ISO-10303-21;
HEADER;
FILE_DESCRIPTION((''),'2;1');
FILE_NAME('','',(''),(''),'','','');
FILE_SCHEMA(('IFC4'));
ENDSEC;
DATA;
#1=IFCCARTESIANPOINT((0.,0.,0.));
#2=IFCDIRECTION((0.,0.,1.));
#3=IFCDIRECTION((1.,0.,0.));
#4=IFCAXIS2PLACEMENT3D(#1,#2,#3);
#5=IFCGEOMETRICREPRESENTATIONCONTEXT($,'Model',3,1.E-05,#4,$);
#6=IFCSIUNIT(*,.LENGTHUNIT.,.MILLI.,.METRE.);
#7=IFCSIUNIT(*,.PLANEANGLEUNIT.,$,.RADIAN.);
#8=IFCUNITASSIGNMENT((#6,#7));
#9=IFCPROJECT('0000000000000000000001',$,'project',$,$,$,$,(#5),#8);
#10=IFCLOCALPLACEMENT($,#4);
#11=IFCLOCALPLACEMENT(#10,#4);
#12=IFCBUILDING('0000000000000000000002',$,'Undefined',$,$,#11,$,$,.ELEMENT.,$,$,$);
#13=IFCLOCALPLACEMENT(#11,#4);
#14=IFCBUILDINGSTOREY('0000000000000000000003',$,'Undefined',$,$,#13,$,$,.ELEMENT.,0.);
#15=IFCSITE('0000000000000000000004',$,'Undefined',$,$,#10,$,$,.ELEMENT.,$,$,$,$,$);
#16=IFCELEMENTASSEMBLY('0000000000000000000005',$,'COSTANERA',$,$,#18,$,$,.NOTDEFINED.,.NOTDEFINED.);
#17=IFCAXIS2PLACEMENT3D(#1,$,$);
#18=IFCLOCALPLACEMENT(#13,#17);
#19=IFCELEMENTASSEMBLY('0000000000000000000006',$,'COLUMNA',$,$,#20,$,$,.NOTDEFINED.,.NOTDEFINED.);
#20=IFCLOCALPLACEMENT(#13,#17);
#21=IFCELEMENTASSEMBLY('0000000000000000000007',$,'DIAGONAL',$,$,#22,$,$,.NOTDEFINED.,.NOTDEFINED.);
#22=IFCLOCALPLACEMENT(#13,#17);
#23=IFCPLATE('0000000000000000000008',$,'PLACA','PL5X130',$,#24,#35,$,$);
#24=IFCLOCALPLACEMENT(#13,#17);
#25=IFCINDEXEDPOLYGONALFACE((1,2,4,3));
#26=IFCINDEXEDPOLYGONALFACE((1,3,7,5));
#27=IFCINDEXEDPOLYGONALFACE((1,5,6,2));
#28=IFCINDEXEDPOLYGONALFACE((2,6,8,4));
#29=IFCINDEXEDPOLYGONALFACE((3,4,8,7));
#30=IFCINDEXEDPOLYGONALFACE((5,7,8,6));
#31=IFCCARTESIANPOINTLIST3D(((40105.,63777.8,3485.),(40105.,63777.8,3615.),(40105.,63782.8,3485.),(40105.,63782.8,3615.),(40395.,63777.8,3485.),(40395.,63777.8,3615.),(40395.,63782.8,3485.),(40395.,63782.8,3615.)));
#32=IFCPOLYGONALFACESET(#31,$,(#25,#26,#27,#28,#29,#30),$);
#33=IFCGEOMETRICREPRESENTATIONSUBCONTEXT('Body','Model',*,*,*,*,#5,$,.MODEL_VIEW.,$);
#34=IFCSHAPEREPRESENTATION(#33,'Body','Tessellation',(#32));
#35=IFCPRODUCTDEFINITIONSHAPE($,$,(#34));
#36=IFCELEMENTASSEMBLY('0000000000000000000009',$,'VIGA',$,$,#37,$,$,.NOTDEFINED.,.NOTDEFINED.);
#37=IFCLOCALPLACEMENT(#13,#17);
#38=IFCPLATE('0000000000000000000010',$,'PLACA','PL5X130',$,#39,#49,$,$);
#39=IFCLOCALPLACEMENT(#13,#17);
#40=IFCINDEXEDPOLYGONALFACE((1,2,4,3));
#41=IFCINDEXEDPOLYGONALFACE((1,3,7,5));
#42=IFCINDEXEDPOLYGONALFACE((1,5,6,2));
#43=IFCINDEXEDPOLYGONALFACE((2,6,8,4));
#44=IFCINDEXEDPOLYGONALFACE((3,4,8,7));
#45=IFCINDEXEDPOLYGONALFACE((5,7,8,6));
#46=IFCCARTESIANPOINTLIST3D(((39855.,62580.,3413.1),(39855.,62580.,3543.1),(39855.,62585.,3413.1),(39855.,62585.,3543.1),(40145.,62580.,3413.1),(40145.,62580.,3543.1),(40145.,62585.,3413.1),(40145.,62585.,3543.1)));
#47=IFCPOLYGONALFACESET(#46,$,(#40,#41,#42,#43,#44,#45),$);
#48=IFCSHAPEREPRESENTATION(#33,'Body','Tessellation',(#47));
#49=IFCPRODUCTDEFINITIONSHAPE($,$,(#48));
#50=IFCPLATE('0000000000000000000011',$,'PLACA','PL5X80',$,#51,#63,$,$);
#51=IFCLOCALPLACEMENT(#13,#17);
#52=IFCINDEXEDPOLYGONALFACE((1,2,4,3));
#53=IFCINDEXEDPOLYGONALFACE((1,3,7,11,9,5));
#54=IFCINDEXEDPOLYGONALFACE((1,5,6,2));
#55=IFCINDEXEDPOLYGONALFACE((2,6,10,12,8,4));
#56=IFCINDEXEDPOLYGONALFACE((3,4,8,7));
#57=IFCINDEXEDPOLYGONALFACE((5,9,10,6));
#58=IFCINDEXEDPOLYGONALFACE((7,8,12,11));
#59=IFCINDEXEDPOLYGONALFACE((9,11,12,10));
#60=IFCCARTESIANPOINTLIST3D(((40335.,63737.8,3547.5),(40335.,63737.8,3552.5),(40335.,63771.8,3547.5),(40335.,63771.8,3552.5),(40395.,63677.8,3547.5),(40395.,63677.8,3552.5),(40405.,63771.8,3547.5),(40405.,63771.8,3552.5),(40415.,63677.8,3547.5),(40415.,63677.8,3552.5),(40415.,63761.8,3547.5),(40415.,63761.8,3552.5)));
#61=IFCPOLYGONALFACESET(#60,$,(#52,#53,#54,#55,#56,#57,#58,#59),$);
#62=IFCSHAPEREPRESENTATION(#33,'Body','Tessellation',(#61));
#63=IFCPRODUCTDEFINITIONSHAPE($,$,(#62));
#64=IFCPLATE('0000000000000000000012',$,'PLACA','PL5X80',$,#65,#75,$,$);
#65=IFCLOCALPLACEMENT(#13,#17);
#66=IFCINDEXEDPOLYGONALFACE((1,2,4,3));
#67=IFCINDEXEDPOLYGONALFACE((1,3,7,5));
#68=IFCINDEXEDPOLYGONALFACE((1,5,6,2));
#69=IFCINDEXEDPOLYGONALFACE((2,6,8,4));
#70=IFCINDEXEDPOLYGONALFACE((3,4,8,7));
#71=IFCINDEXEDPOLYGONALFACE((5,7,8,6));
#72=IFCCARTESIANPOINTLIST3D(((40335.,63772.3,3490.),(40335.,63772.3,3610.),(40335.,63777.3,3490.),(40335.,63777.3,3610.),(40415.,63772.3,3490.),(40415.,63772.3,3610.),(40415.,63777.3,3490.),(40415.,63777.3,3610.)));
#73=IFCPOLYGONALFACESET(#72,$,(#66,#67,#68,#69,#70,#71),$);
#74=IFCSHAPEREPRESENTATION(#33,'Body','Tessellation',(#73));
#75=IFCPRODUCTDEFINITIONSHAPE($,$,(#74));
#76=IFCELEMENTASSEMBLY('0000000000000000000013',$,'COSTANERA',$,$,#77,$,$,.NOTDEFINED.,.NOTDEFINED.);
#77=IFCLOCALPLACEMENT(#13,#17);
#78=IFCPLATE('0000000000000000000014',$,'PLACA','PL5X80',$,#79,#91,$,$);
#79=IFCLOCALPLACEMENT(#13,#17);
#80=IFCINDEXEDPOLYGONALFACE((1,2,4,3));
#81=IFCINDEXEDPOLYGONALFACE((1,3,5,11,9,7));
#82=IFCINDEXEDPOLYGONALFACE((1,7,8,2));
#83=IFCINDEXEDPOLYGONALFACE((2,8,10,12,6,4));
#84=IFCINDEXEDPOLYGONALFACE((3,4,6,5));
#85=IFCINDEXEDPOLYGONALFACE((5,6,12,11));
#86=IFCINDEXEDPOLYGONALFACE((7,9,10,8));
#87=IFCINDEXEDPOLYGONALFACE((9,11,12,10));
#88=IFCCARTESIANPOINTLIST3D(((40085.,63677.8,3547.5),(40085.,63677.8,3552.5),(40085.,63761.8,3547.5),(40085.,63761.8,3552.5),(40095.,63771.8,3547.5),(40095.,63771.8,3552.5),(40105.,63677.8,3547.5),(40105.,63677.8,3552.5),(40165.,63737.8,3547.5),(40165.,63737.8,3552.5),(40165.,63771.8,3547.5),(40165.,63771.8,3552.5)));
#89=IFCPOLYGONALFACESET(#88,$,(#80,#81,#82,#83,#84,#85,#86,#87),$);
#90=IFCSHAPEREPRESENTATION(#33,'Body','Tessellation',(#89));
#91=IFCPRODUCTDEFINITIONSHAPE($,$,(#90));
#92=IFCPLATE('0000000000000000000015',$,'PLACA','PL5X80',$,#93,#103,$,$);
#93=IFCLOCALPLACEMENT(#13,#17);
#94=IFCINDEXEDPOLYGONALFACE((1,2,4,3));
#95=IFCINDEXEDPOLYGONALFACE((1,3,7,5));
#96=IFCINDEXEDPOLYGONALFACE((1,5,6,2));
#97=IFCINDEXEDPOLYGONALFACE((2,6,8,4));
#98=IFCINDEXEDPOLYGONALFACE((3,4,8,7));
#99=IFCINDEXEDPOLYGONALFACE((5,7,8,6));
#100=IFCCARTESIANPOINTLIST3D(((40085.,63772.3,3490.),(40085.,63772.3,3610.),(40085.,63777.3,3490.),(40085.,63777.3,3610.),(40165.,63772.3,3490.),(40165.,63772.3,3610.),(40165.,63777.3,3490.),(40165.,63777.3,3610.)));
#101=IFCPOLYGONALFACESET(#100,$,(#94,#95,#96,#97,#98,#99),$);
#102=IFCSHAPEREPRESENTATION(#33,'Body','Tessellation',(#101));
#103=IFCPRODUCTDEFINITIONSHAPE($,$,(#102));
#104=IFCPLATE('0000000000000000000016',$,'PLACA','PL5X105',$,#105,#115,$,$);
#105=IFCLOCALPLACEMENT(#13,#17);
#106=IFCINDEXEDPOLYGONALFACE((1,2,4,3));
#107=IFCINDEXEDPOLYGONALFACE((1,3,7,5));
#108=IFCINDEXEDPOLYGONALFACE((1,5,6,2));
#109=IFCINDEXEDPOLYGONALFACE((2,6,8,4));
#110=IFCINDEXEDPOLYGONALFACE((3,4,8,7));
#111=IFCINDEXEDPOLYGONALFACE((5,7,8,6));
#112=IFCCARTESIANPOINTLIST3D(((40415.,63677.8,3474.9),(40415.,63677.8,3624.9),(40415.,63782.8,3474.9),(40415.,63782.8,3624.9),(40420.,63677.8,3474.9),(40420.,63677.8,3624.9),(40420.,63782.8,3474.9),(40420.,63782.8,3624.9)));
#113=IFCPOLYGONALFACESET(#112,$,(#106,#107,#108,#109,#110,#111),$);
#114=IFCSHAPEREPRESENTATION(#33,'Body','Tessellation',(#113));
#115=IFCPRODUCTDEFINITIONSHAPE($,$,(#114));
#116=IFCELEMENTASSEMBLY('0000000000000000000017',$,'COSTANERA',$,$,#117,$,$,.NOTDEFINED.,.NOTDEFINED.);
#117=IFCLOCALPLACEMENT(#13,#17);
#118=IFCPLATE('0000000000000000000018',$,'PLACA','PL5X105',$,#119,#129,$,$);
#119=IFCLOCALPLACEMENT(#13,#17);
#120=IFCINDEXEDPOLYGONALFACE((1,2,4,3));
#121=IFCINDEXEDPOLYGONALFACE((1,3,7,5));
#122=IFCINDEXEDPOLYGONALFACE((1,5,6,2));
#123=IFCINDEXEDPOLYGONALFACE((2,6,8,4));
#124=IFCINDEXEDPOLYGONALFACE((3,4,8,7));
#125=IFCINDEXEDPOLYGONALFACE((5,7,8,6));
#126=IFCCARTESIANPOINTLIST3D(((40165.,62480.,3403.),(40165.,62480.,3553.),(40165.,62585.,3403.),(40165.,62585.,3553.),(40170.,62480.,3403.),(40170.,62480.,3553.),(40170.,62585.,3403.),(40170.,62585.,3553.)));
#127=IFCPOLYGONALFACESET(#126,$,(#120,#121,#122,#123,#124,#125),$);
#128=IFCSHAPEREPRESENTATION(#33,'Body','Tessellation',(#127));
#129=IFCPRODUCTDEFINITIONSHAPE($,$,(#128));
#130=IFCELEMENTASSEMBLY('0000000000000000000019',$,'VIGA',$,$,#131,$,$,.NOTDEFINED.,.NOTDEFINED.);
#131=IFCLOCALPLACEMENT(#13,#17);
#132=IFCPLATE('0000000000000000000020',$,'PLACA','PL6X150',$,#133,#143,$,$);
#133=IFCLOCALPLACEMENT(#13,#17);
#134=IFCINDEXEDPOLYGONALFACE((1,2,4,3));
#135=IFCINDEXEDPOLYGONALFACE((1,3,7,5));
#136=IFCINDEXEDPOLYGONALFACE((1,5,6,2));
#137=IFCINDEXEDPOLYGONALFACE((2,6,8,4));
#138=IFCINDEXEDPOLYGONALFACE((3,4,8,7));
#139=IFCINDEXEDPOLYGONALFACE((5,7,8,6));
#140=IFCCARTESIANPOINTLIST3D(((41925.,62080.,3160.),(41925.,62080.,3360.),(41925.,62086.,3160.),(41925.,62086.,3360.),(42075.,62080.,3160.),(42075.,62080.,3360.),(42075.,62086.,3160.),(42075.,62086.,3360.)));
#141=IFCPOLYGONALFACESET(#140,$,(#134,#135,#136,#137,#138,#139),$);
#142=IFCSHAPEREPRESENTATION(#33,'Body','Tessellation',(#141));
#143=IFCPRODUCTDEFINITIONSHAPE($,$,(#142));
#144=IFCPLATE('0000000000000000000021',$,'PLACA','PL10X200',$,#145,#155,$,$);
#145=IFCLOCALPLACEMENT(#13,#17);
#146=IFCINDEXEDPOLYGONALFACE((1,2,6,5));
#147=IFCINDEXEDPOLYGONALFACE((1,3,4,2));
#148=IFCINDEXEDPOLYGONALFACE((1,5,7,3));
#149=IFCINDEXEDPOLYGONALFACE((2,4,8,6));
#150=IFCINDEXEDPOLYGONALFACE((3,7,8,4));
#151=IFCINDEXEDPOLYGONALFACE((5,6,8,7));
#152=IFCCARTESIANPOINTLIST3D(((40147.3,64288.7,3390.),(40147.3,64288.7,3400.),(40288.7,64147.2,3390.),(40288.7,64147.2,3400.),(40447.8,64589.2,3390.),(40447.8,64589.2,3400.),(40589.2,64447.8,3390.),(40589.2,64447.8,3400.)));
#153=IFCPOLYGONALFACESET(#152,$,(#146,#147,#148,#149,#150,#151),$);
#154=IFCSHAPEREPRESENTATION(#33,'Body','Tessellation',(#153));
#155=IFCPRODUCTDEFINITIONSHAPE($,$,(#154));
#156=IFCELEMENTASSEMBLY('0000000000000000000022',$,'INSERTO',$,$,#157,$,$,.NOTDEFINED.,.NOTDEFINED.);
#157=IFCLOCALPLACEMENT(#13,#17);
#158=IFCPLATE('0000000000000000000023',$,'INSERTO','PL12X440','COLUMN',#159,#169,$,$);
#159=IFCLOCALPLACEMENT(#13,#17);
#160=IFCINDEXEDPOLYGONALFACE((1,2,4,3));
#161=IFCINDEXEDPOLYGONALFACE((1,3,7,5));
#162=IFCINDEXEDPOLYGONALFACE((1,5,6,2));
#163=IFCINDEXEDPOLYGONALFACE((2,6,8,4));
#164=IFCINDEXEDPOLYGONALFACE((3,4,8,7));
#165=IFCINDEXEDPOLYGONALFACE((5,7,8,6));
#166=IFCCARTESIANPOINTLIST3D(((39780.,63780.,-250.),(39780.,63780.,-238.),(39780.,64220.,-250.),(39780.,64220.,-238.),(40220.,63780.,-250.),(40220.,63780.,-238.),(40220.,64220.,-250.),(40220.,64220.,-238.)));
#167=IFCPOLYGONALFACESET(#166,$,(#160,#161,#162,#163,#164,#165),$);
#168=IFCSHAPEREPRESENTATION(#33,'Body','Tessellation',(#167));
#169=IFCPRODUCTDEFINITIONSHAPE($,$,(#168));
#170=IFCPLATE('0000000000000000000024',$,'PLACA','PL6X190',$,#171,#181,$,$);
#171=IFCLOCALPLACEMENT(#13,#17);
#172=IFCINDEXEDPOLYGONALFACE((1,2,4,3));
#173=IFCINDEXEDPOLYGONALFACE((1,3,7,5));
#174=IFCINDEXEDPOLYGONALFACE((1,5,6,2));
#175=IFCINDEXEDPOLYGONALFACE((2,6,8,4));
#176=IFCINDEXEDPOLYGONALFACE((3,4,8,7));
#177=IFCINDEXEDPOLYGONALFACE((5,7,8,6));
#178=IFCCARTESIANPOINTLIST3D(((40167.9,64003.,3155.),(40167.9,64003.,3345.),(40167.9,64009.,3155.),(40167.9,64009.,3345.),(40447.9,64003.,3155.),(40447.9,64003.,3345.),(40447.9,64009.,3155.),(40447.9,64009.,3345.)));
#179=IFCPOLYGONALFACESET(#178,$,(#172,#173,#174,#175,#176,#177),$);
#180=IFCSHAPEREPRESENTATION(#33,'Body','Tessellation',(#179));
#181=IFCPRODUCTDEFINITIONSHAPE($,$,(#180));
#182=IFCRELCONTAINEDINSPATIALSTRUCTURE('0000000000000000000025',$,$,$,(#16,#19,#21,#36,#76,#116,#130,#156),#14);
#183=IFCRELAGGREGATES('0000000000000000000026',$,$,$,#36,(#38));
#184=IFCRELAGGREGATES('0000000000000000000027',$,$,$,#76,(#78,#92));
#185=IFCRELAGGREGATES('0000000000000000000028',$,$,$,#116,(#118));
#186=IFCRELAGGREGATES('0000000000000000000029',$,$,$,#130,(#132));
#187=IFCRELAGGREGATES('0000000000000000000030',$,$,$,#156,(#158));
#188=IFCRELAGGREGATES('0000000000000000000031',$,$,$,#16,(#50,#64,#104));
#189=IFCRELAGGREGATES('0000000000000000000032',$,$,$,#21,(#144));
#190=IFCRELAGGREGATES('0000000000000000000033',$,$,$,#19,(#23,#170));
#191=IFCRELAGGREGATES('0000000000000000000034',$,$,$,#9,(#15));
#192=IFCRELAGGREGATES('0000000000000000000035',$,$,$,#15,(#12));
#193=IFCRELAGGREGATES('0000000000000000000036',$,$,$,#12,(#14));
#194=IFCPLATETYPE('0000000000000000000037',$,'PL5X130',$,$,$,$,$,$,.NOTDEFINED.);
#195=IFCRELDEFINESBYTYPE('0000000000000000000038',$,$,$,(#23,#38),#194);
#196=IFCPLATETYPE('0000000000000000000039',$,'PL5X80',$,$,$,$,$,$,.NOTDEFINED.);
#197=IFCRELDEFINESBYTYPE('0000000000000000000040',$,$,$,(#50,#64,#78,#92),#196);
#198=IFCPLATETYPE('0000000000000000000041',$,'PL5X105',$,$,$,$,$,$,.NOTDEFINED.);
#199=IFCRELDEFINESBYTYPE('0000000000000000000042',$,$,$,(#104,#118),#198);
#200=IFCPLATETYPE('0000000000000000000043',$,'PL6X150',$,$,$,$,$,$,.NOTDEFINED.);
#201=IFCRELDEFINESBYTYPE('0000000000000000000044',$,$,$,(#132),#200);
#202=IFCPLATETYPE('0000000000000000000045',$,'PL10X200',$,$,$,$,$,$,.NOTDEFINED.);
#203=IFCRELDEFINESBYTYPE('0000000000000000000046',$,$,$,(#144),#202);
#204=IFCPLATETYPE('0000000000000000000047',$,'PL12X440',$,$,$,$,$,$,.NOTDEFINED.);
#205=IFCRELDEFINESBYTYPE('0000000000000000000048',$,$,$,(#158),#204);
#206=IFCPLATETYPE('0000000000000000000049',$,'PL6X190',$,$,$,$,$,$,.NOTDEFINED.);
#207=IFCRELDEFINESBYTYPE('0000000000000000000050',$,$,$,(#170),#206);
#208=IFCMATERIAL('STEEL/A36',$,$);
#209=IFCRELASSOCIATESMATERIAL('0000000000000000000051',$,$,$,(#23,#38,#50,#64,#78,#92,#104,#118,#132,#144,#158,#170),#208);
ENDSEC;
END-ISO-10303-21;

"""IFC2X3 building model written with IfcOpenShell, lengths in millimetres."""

from ifc_helpers import new_model, si_unit, frame, origin_with_axes, place, context, subcontext, project, spatial, polyline, outline, extrude, material, type_object, element, aggregate, save


model = new_model("IFC2X3")

# Units and contexts
model_context = context("Model", 3, precision=1e-05, world=origin_with_axes())
body_context = subcontext(model_context, "Body", "Model", "MODEL_VIEW")
ifc_project = project(units=[si_unit("LENGTHUNIT", "METRE", prefix="MILLI"), si_unit("PLANEANGLEUNIT", "RADIAN")], contexts=[model_context])

# Site, building, storey
site_placement = place(None, origin_with_axes())
site = spatial("IfcSite", under=ifc_project, at=site_placement, Name="Undefined", CompositionType="ELEMENT")
building_placement = place(site_placement, origin_with_axes())
building = spatial("IfcBuilding", under=site, at=building_placement, Name="Undefined", CompositionType="ELEMENT")
storey_placement = place(building_placement, origin_with_axes())
storey = spatial("IfcBuildingStorey", under=building, at=storey_placement, Name="Undefined", CompositionType="ELEMENT", Elevation=0.0)

# Shared definitions
ifc_material_1 = material(Name="STEEL/A36")

# Element assemblies
assembly_1_placement = place(storey_placement, origin_with_axes())
assembly_1 = element("IfcElementAssembly", 1, at=assembly_1_placement, inside=storey, Name="COSTANERA", AssemblyPlace="NOTDEFINED", PredefinedType="NOTDEFINED")
assembly_2_placement = place(storey_placement, origin_with_axes())
assembly_2 = element("IfcElementAssembly", 2, at=assembly_2_placement, inside=storey, Name="COLUMNA", AssemblyPlace="NOTDEFINED", PredefinedType="NOTDEFINED")

# Element assembly
assembly_3_placement = place(storey_placement, origin_with_axes())
assembly_3 = element("IfcElementAssembly", 3, at=assembly_3_placement, inside=storey, Name="DIAGONAL", AssemblyPlace="NOTDEFINED", PredefinedType="NOTDEFINED")

# Plate
plate_type_1 = type_object("IfcPlateType", Name="PL5X130", PredefinedType="NOTDEFINED")
plate_1_placement = place(assembly_2_placement, frame((40395.0, 63780.3, 3615.0), z_axis=(0.0, -1.0, 0.0), x_axis=(-1.0, 0.0, 0.0)))
plate_1 = element("IfcPlate", 4, at=plate_1_placement, type_object=plate_type_1, material=ifc_material_1, Name="PLACA", Description="PL5X130", context=body_context, shape_type="SweptSolid", body=[
    extrude(outline(polyline([(0.0, 0.0), (290.0, 0.0), (290.0, 130.0), (0.0, 130.0), (0.0, 0.0)])), frame((0.0, 0.0, -2.5), z_axis=(0.0, 0.0, 1.0), x_axis=(1.0, 0.0, 0.0)), (0.0, 0.0, 1.0), 5.0),
])

# Element assembly, plate
assembly_4_placement = place(storey_placement, origin_with_axes())
assembly_4 = element("IfcElementAssembly", 5, at=assembly_4_placement, inside=storey, Name="VIGA", AssemblyPlace="NOTDEFINED", PredefinedType="NOTDEFINED")
plate_2_placement = place(assembly_4_placement, frame((40145.0, 62582.5, 3543.1), z_axis=(0.0, -1.0, 0.0), x_axis=(-1.0, 0.0, 0.0)))
plate_2 = element("IfcPlate", 6, at=plate_2_placement, type_object=plate_type_1, material=ifc_material_1, Name="PLACA", Description="PL5X130", context=body_context, shape_type="SweptSolid", body=[
    extrude(outline(polyline([(0.0, 0.0), (290.0, 0.0), (290.0, 130.0), (0.0, 130.0), (0.0, 0.0)])), frame((0.0, 0.0, -2.5), z_axis=(0.0, 0.0, 1.0), x_axis=(1.0, 0.0, 0.0)), (0.0, 0.0, 1.0), 5.0),
])
aggregate(assembly_4, [plate_2])

# Plates
plate_type_2 = type_object("IfcPlateType", Name="PL5X80", PredefinedType="NOTDEFINED")
plate_3_placement = place(assembly_1_placement, frame((40335.0, 63771.8, 3550.0), z_axis=(0.0, 0.0, -1.0), x_axis=(1.0, 0.0, 0.0)))
plate_3 = element("IfcPlate", 7, at=plate_3_placement, type_object=plate_type_2, material=ifc_material_1, Name="PLACA", Description="PL5X80", context=body_context, shape_type="SweptSolid", body=[
    extrude(outline(polyline([(0.0, 0.0), (70.0, 0.0), (80.0, 10.0), (80.0, 94.0), (60.0, 94.0), (0.0, 34.0), (0.0, 0.0)])), frame((0.0, 0.0, -2.5), z_axis=(0.0, 0.0, 1.0), x_axis=(1.0, 0.0, 0.0)), (0.0, 0.0, 1.0), 5.0),
])
plate_4_placement = place(assembly_1_placement, frame((40335.0, 63774.8, 3610.0), z_axis=(0.0, 1.0, 0.0), x_axis=(1.0, 0.0, 0.0)))
plate_4 = element("IfcPlate", 8, at=plate_4_placement, type_object=plate_type_2, material=ifc_material_1, Name="PLACA", Description="PL5X80", context=body_context, shape_type="SweptSolid", body=[
    extrude(outline(polyline([(0.0, 0.0), (80.0, 0.0), (80.0, 120.0), (0.0, 120.0), (0.0, 0.0)])), frame((0.0, 0.0, -2.5), z_axis=(0.0, 0.0, 1.0), x_axis=(1.0, 0.0, 0.0)), (0.0, 0.0, 1.0), 5.0),
])

# Element assembly, plates
assembly_5_placement = place(storey_placement, origin_with_axes())
assembly_5 = element("IfcElementAssembly", 9, at=assembly_5_placement, inside=storey, Name="COSTANERA", AssemblyPlace="NOTDEFINED", PredefinedType="NOTDEFINED")
plate_5_placement = place(assembly_5_placement, frame((40165.0, 63771.8, 3550.0), z_axis=(0.0, 0.0, 1.0), x_axis=(-1.0, 0.0, 0.0)))
plate_5 = element("IfcPlate", 10, at=plate_5_placement, type_object=plate_type_2, material=ifc_material_1, Name="PLACA", Description="PL5X80", context=body_context, shape_type="SweptSolid", body=[
    extrude(outline(polyline([(0.0, 0.0), (70.0, 0.0), (80.0, 10.0), (80.0, 94.0), (60.0, 94.0), (0.0, 34.0), (0.0, 0.0)])), frame((0.0, 0.0, -2.5), z_axis=(0.0, 0.0, 1.0), x_axis=(1.0, 0.0, 0.0)), (0.0, 0.0, 1.0), 5.0),
])
plate_6_placement = place(assembly_5_placement, frame((40165.0, 63774.8, 3610.0), z_axis=(0.0, -1.0, 0.0), x_axis=(-1.0, 0.0, 0.0)))
plate_6 = element("IfcPlate", 11, at=plate_6_placement, type_object=plate_type_2, material=ifc_material_1, Name="PLACA", Description="PL5X80", context=body_context, shape_type="SweptSolid", body=[
    extrude(outline(polyline([(0.0, 0.0), (80.0, 0.0), (80.0, 120.0), (0.0, 120.0), (0.0, 0.0)])), frame((0.0, 0.0, -2.5), z_axis=(0.0, 0.0, 1.0), x_axis=(1.0, 0.0, 0.0)), (0.0, 0.0, 1.0), 5.0),
])
aggregate(assembly_5, [plate_5, plate_6])

# Plate
plate_type_3 = type_object("IfcPlateType", Name="PL5X105", PredefinedType="NOTDEFINED")
plate_7_placement = place(assembly_1_placement, frame((40417.5, 63677.8, 3474.9), z_axis=(1.0, 0.0, 0.0), x_axis=(0.0, 1.0, 0.0)))
plate_7 = element("IfcPlate", 12, at=plate_7_placement, type_object=plate_type_3, material=ifc_material_1, Name="PLACA", Description="PL5X105", context=body_context, shape_type="SweptSolid", body=[
    extrude(outline(polyline([(0.0, 0.0), (105.0, 0.0), (105.0, 150.0), (0.0, 150.0), (0.0, 0.0)])), frame((0.0, 0.0, -2.5), z_axis=(0.0, 0.0, 1.0), x_axis=(1.0, 0.0, 0.0)), (0.0, 0.0, 1.0), 5.0),
])

# Element assemblies, plates
assembly_6_placement = place(storey_placement, origin_with_axes())
assembly_6 = element("IfcElementAssembly", 13, at=assembly_6_placement, inside=storey, Name="COSTANERA", AssemblyPlace="NOTDEFINED", PredefinedType="NOTDEFINED")
plate_8_placement = place(assembly_6_placement, frame((40167.5, 62480.0, 3403.0), z_axis=(1.0, 0.0, 0.0), x_axis=(0.0, 1.0, 0.0)))
plate_8 = element("IfcPlate", 14, at=plate_8_placement, type_object=plate_type_3, material=ifc_material_1, Name="PLACA", Description="PL5X105", context=body_context, shape_type="SweptSolid", body=[
    extrude(outline(polyline([(0.0, 0.0), (105.0, 0.0), (105.0, 150.0), (0.0, 150.0), (0.0, 0.0)])), frame((0.0, 0.0, -2.5), z_axis=(0.0, 0.0, 1.0), x_axis=(1.0, 0.0, 0.0)), (0.0, 0.0, 1.0), 5.0),
])
aggregate(assembly_6, [plate_8])
assembly_7_placement = place(storey_placement, origin_with_axes())
assembly_7 = element("IfcElementAssembly", 15, at=assembly_7_placement, inside=storey, Name="VIGA", AssemblyPlace="NOTDEFINED", PredefinedType="NOTDEFINED")
plate_type_4 = type_object("IfcPlateType", Name="PL6X150", PredefinedType="NOTDEFINED")
plate_9_placement = place(assembly_7_placement, frame((41925.0, 62083.0, 3360.0), z_axis=(0.0, 1.0, 0.0), x_axis=(1.0, 0.0, 0.0)))
plate_9 = element("IfcPlate", 16, at=plate_9_placement, type_object=plate_type_4, material=ifc_material_1, Name="PLACA", Description="PL6X150", context=body_context, shape_type="SweptSolid", body=[
    extrude(outline(polyline([(0.0, 0.0), (150.0, 0.0), (150.0, 200.0), (0.0, 200.0), (0.0, 0.0)])), frame((0.0, 0.0, -3.0), z_axis=(0.0, 0.0, 1.0), x_axis=(1.0, 0.0, 0.0)), (0.0, 0.0, 1.0), 6.0),
])
aggregate(assembly_7, [plate_9])

# Plate
plate_type_5 = type_object("IfcPlateType", Name="PL10X200", PredefinedType="NOTDEFINED")
plate_10_placement = place(assembly_3_placement, frame((40218.0, 64218.0, 3395.0), z_axis=(0.0, 0.0, -1.0), x_axis=(0.707107, 0.707107, 0.0)))
plate_10 = element("IfcPlate", 17, at=plate_10_placement, type_object=plate_type_5, material=ifc_material_1, Name="PLACA", Description="PL10X200", context=body_context, shape_type="SweptSolid", body=[
    extrude(outline(polyline([(0.0, -100.0), (0.0, 100.0), (425.0, 100.0), (425.0, -100.0), (0.0, -100.0)])), frame((0.0, 0.0, -5.0), z_axis=(0.0, 0.0, 1.0), x_axis=(1.0, 0.0, 0.0)), (0.0, 0.0, 1.0), 10.0),
])

# Element assembly, plate
assembly_8_placement = place(storey_placement, origin_with_axes())
assembly_8 = element("IfcElementAssembly", 18, at=assembly_8_placement, inside=storey, Name="INSERTO", AssemblyPlace="NOTDEFINED", PredefinedType="NOTDEFINED")
plate_type_6 = type_object("IfcPlateType", Name="PL12X440", PredefinedType="NOTDEFINED")
plate_11_placement = place(assembly_8_placement, frame((40220.0, 64000.0, -244.0), z_axis=(0.0, 0.0, 1.0), x_axis=(-1.0, 0.0, 0.0)))
plate_11 = element("IfcPlate", 19, at=plate_11_placement, type_object=plate_type_6, material=ifc_material_1, Name="INSERTO", Description="PL12X440", ObjectType="COLUMN", context=body_context, shape_type="SweptSolid", body=[
    extrude(outline(polyline([(0.0, -220.0), (0.0, 220.0), (440.0, 220.0), (440.0, -220.0), (0.0, -220.0)])), frame((0.0, 0.0, -6.0), z_axis=(0.0, 0.0, 1.0), x_axis=(1.0, 0.0, 0.0)), (0.0, 0.0, 1.0), 12.0),
])
aggregate(assembly_8, [plate_11])

# Plate
plate_type_7 = type_object("IfcPlateType", Name="PL6X190", PredefinedType="NOTDEFINED")
plate_12_placement = place(assembly_2_placement, frame((40447.9, 64006.0, 3250.0), z_axis=(0.0, 1.0, 0.0), x_axis=(-1.0, 0.0, 0.0)))
plate_12 = element("IfcPlate", 20, at=plate_12_placement, type_object=plate_type_7, material=ifc_material_1, Name="PLACA", Description="PL6X190", context=body_context, shape_type="SweptSolid", body=[
    extrude(outline(polyline([(0.0, -95.0), (0.0, 95.0), (280.0, 95.0), (280.0, -95.0), (0.0, -95.0)])), frame((0.0, 0.0, -3.0), z_axis=(0.0, 0.0, 1.0), x_axis=(1.0, 0.0, 0.0)), (0.0, 0.0, 1.0), 6.0),
])

aggregate(assembly_1, [plate_3, plate_4, plate_7])
aggregate(assembly_3, [plate_10])
aggregate(assembly_2, [plate_1, plate_12])

save(model, "model.ifc")
